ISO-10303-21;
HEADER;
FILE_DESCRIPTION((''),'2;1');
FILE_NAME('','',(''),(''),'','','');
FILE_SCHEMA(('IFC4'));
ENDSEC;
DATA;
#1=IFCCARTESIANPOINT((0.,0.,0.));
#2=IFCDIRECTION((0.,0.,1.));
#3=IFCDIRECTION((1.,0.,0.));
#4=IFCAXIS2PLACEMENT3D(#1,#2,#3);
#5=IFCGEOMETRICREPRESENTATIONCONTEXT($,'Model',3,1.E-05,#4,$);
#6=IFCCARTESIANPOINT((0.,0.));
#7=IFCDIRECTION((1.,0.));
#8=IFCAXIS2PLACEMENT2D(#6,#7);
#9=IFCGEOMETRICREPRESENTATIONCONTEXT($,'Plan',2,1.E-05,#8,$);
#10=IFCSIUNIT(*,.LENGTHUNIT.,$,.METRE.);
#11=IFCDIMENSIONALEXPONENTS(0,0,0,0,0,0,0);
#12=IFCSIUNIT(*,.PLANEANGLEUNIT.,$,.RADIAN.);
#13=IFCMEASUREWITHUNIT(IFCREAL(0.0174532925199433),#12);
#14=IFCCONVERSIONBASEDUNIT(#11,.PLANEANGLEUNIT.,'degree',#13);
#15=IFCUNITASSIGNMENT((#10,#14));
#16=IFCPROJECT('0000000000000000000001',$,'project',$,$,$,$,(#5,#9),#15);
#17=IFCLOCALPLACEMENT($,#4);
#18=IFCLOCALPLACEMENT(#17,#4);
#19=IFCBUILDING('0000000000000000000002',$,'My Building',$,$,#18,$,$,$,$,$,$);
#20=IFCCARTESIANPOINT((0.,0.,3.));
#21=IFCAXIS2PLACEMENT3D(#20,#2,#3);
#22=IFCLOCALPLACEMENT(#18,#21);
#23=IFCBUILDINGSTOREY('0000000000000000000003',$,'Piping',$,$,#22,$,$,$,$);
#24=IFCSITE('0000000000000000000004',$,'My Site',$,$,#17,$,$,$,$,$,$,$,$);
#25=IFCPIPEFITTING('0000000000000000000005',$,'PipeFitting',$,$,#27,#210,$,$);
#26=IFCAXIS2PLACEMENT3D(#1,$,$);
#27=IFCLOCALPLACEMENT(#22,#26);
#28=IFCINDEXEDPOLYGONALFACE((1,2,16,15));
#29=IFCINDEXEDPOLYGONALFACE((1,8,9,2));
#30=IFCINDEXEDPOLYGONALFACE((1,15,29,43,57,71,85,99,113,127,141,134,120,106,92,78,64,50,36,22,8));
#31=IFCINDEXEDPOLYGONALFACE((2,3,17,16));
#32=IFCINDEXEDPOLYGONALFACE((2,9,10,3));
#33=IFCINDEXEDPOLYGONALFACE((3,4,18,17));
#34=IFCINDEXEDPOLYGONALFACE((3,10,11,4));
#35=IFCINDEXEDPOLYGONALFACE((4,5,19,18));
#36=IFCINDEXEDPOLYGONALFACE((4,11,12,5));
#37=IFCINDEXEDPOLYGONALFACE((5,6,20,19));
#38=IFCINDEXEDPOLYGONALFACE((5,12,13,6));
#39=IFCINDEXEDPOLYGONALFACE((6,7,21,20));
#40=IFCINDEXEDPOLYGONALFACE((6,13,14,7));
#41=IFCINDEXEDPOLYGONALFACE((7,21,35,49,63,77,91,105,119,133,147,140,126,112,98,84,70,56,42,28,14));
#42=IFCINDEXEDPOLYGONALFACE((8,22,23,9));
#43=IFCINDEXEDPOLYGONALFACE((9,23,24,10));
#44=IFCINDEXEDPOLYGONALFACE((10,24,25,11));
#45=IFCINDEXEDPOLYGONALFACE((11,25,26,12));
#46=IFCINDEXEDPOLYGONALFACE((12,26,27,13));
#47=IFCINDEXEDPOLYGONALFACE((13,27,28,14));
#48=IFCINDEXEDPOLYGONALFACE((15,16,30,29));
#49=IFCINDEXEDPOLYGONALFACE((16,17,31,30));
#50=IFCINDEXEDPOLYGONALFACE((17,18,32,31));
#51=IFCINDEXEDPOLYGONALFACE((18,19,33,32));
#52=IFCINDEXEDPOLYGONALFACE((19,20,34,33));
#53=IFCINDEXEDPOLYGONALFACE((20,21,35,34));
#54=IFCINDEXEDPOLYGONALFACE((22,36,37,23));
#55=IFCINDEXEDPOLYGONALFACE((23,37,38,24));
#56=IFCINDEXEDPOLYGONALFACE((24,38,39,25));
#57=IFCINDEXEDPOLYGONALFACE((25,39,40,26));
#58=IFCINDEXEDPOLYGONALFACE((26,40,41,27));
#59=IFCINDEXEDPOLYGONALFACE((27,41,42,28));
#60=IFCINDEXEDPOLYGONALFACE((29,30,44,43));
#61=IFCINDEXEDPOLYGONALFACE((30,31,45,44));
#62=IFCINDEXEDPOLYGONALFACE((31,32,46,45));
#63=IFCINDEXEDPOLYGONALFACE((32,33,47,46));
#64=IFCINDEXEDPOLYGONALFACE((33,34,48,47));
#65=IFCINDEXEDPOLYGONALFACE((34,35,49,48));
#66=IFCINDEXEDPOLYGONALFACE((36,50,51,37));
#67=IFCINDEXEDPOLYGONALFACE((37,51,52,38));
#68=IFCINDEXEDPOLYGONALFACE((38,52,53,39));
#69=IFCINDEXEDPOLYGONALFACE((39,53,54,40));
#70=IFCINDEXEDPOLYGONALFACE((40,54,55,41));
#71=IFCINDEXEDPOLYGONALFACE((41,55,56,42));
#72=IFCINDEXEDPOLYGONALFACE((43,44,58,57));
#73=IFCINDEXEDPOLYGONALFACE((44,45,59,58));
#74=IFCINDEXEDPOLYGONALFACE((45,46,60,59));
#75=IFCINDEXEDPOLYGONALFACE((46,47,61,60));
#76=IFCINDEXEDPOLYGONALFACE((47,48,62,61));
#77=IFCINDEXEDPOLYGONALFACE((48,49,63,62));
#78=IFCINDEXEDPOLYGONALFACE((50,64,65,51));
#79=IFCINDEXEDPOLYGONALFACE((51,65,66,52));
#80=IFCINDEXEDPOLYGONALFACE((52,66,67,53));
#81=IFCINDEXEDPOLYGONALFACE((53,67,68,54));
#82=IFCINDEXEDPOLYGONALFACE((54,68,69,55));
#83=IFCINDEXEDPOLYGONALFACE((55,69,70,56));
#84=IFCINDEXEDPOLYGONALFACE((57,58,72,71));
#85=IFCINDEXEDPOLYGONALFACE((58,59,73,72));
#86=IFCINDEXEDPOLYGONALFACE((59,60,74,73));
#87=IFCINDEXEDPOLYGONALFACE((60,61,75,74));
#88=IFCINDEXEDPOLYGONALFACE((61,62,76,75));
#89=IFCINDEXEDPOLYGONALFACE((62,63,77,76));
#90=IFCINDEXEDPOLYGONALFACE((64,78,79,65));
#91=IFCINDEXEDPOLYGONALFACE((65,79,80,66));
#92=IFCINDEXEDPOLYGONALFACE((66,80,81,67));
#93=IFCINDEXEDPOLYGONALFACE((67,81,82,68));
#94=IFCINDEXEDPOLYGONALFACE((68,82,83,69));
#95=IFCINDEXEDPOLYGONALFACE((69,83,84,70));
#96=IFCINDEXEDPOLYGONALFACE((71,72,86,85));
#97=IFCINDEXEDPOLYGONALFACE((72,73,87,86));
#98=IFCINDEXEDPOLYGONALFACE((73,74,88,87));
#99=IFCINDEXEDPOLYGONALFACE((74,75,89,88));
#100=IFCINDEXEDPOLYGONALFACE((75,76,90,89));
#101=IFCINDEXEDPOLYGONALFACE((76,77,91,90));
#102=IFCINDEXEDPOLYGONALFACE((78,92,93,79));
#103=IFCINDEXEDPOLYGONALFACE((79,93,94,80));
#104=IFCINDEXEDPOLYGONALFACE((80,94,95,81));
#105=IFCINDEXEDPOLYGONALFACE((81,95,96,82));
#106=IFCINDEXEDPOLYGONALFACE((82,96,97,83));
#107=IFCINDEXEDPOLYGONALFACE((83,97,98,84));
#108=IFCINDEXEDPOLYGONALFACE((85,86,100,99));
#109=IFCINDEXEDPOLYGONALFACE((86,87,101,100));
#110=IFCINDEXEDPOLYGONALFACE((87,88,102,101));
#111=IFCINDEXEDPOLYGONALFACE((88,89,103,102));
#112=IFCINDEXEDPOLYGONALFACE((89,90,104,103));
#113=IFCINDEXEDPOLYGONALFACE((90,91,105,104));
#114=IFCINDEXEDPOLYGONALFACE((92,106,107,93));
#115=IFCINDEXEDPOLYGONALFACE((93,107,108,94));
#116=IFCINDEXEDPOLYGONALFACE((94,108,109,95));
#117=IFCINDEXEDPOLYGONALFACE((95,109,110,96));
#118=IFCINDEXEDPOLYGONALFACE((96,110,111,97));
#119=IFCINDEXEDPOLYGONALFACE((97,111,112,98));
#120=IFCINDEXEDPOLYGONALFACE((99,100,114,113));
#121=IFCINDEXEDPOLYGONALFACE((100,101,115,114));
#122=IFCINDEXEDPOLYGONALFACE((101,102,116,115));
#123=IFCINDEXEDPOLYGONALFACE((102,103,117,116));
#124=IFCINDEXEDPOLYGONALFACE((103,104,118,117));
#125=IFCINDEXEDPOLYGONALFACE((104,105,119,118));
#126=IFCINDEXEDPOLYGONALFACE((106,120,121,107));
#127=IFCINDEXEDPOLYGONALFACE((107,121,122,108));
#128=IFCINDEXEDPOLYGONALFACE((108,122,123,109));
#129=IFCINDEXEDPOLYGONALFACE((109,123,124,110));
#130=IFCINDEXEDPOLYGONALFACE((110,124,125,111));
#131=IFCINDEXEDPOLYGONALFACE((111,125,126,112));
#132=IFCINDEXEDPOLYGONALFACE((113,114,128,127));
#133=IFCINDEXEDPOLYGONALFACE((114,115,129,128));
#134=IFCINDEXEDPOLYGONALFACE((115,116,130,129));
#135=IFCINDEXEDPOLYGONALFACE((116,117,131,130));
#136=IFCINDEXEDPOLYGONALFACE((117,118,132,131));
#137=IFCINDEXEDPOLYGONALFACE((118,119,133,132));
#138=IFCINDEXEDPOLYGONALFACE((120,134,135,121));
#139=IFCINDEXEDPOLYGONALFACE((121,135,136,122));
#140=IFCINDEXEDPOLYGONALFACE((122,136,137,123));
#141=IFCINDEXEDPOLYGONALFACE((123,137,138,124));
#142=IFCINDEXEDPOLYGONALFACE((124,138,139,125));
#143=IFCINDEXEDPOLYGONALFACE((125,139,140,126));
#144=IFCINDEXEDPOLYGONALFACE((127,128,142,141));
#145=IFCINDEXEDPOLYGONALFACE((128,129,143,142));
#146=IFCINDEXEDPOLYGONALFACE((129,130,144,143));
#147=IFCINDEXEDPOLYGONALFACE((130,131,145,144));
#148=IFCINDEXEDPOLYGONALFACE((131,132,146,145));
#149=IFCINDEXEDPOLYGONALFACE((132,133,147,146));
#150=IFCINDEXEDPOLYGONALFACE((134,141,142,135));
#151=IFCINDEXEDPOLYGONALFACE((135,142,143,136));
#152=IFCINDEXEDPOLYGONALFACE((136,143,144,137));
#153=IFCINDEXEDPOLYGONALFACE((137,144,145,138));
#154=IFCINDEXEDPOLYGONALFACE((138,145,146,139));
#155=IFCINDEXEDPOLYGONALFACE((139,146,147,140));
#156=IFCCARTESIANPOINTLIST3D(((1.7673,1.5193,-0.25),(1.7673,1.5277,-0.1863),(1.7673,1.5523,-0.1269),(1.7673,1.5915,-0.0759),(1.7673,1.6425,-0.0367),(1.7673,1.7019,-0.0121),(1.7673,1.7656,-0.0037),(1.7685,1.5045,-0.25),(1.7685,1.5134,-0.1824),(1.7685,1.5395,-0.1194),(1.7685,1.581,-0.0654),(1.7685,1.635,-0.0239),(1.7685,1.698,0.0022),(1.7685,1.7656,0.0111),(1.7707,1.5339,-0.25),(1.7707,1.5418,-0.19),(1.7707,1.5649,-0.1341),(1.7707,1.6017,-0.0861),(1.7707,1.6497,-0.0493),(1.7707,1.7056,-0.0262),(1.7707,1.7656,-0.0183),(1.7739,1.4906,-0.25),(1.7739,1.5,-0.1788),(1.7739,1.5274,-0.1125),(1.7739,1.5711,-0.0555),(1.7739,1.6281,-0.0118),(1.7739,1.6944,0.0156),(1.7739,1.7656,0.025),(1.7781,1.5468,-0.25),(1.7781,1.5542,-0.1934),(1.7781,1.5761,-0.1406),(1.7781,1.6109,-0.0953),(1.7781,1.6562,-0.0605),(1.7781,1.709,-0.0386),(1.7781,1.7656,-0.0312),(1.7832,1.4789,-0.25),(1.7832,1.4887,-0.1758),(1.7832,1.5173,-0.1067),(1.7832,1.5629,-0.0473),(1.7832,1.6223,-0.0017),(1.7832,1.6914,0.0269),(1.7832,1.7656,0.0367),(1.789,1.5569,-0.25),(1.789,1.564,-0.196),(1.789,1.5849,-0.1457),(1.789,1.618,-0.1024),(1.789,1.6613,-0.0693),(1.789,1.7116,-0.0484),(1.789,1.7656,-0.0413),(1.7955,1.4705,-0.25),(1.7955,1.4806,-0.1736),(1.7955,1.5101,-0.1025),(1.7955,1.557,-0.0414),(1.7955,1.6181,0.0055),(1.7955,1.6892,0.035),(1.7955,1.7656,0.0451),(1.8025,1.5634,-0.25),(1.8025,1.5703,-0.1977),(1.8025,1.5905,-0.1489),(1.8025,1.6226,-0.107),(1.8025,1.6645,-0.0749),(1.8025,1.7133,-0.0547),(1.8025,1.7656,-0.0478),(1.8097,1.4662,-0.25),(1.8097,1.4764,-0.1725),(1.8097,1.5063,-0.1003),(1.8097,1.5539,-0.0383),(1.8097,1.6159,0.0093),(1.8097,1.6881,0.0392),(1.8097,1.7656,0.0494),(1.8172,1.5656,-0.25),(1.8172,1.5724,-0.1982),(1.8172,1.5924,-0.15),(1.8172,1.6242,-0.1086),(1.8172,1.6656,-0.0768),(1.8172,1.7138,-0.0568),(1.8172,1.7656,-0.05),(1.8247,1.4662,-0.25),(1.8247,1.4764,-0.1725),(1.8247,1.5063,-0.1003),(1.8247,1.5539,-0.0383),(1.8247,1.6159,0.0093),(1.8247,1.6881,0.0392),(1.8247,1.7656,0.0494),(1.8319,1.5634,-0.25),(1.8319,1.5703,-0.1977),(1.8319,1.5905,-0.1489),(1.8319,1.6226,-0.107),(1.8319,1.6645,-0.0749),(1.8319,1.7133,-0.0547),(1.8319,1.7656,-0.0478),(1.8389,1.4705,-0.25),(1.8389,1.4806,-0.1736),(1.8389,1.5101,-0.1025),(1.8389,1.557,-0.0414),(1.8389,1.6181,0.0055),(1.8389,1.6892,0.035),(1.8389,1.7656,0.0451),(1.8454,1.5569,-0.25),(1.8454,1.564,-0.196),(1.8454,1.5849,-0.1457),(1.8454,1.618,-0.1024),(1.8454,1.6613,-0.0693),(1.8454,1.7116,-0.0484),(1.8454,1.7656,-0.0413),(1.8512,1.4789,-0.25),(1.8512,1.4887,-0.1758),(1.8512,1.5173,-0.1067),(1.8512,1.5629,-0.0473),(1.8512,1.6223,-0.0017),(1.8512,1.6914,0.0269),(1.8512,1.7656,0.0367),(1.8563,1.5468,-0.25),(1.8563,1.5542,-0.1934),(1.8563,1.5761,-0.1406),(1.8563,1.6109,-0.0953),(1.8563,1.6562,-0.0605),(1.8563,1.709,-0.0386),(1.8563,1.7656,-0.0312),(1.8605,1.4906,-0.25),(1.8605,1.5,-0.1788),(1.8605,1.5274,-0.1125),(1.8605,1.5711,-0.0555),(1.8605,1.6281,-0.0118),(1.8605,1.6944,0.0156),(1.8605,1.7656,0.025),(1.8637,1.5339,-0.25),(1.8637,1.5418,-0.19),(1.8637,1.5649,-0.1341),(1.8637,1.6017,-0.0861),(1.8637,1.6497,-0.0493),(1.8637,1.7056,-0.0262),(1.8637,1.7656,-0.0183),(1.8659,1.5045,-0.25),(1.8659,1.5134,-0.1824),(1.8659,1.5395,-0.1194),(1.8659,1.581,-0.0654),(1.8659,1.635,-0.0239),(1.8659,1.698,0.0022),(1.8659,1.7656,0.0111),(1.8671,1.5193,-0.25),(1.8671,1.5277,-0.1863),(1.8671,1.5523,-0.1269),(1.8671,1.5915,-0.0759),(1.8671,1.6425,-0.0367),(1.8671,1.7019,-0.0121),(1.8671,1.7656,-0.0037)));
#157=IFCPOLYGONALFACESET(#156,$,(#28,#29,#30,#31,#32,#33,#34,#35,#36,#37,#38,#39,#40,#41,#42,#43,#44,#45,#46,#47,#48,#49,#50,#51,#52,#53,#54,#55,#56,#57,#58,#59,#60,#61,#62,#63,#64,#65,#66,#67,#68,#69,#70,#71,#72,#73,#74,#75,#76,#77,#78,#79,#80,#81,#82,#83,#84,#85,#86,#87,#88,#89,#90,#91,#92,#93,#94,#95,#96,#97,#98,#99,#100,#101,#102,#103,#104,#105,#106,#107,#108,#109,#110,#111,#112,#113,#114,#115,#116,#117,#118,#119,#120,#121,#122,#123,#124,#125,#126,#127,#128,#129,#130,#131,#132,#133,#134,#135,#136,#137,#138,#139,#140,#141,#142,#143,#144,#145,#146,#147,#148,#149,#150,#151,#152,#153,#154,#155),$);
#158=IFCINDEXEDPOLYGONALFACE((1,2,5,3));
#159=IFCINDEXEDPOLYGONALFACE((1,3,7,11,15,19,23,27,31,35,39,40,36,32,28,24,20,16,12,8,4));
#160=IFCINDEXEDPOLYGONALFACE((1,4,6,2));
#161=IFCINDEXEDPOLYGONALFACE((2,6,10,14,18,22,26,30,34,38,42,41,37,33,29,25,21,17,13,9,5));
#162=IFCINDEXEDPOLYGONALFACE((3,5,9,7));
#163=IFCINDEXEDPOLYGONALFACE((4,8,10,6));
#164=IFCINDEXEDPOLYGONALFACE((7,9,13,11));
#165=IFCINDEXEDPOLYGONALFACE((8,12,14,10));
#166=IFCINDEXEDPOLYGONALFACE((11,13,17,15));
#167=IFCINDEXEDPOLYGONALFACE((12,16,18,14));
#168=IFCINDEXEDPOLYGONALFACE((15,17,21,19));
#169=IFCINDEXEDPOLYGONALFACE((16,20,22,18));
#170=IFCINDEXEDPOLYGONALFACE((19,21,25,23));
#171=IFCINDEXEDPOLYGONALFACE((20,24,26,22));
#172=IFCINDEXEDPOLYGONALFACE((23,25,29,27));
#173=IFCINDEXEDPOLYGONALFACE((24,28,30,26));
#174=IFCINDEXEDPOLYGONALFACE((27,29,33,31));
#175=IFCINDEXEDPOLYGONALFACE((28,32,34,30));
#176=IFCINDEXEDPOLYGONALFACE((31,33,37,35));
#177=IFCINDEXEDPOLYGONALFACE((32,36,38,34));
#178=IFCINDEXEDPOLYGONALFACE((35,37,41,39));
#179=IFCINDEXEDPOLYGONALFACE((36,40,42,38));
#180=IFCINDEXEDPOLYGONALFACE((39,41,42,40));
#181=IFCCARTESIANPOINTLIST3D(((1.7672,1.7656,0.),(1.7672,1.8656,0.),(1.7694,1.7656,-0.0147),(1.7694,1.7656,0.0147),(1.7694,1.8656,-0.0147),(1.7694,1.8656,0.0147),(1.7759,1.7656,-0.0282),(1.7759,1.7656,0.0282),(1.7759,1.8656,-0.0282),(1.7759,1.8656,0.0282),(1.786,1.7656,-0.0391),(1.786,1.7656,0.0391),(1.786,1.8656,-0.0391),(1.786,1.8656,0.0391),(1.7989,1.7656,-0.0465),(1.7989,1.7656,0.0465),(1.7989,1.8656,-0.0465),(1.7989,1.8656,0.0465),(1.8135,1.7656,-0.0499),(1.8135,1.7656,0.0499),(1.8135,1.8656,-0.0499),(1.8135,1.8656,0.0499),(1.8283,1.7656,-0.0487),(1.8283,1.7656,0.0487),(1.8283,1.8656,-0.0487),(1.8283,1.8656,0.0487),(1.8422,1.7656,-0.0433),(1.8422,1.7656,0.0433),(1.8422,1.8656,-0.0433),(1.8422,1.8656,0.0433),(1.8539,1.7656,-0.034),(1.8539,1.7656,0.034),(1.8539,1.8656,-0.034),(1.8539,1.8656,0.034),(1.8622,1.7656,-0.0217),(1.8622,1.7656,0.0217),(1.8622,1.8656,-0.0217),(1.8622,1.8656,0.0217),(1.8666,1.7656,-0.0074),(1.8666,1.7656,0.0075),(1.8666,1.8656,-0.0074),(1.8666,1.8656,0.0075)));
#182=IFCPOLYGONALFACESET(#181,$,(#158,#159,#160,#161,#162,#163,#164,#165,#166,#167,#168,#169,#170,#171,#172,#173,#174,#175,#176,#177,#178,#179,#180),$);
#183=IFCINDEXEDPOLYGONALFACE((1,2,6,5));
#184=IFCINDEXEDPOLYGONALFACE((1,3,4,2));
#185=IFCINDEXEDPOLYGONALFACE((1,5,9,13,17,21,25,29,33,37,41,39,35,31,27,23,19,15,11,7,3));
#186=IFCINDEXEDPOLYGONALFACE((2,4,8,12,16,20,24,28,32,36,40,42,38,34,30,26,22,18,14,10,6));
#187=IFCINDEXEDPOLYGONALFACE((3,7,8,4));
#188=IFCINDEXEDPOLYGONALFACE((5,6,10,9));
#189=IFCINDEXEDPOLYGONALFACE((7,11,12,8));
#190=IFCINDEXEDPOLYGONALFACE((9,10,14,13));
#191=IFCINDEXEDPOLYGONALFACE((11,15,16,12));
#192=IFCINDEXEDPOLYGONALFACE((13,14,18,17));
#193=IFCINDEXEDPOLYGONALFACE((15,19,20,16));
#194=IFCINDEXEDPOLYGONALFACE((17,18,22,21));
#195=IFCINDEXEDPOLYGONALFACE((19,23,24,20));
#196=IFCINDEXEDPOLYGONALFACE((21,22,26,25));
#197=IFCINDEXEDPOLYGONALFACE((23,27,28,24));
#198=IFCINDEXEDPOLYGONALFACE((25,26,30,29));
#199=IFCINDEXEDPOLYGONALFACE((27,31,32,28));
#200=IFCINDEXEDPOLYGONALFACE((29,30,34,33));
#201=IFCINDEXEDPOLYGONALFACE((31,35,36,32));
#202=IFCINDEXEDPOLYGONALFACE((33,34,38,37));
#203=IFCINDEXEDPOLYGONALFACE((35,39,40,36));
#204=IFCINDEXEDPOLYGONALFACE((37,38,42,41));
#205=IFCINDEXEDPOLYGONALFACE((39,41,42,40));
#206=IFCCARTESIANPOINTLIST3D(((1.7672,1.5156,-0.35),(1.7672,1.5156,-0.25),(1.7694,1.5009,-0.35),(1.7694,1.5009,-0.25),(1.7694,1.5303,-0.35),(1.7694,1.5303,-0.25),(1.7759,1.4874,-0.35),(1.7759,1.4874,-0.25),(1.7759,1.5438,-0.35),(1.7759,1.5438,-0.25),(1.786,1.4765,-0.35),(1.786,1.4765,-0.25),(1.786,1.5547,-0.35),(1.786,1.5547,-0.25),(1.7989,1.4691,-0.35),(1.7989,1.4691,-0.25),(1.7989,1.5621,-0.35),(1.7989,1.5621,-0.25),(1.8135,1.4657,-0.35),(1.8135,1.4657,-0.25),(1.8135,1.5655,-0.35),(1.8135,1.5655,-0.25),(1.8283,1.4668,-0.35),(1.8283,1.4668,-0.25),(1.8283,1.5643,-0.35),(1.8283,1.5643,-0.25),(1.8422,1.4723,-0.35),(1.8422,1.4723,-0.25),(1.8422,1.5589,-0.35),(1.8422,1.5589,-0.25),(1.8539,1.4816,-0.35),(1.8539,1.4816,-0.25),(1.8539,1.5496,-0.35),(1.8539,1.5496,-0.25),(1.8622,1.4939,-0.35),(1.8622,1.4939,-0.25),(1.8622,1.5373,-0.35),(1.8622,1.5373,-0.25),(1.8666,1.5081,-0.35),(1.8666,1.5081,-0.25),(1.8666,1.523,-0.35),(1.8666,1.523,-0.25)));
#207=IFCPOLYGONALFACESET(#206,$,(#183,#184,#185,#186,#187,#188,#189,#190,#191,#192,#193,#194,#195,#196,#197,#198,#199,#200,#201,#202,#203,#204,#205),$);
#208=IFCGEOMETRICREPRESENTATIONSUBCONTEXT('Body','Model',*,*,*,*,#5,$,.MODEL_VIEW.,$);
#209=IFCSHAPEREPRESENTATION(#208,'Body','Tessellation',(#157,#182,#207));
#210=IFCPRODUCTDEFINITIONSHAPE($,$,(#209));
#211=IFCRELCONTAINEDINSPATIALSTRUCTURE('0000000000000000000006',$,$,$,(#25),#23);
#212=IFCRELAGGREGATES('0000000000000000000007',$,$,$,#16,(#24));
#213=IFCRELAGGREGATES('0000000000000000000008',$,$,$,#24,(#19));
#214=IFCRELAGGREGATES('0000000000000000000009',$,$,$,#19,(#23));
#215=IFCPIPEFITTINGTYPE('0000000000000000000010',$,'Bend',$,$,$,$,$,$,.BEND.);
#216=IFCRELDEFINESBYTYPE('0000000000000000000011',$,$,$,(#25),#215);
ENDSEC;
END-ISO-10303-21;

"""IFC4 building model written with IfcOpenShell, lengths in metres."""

from ifc_helpers import new_model, entity, si_unit, converted_unit, frame, origin_with_axes, origin_2d_with_axis, place, context, subcontext, project, spatial, circle, extrude, source, transform, mapped, type_object, type_shapes, element, save


model = new_model("IFC4")

# Units and contexts
model_context = context("Model", 3, precision=1e-05, world=origin_with_axes())
plan_context = context("Plan", 2, precision=1e-05, world=origin_2d_with_axis())
body_context = subcontext(model_context, "Body", "Model", "MODEL_VIEW")
ifc_project = project(units=[si_unit("LENGTHUNIT", "METRE"), converted_unit("PLANEANGLEUNIT", "degree", entity("IfcReal", 0.0174532925199433), si_unit("PLANEANGLEUNIT", "RADIAN"), dimensions=[0, 0, 0, 0, 0, 0, 0])], contexts=[model_context, plan_context])

# Site, building, storey
site_placement = place(None, origin_with_axes())
site = spatial("IfcSite", under=ifc_project, at=site_placement, Name="My Site")
building_placement = place(site_placement, origin_with_axes())
building = spatial("IfcBuilding", under=site, at=building_placement, Name="My Building")
storey_placement = place(building_placement, frame((0.0, 0.0, 3.0), z_axis=(0.0, 0.0, 1.0), x_axis=(1.0, 0.0, 0.0)))
storey = spatial("IfcBuildingStorey", under=building, at=storey_placement, Name="Piping")

# Shared definitions
pipe_fitting_type = type_object("IfcPipeFittingType", Name="Bend", PredefinedType="BEND")
shared_shape = source(origin_with_axes(), body_context, "Body", "SolidModel", [
    entity("IfcSweptDiskSolid", entity("IfcIndexedPolyCurve", entity("IfcCartesianPointList3D", [[0.0, 0.0, -0.1], [0.0, -0.0732, -0.2768], [0.0, -0.25, -0.35]]), [entity("IfcArcIndex", [1, 2, 3])]), 0.05),
    extrude(circle(Radius=0.05), origin_with_axes(), (0.0, 0.0, -1.0), 0.1),
    extrude(circle(Radius=0.05), frame((0.0, -0.25, -0.35), z_axis=(0.0, -1.0, 0.0), x_axis=(1.0, 0.0, 0.0)), (0.0, 0.0, 1.0), 0.1),
])
type_shapes(pipe_fitting_type, [shared_shape])

# Pipe fitting
for number, where, z_axis, x_axis, name in (
    (1, (1.8172, 1.8656, 0.0), (0.0, 1.0, 0.0), (-1.0, 0.0, 0.0), "PipeFitting"),
):
    element("IfcPipeFitting", number, at=place(storey_placement, frame(where, z_axis=z_axis, x_axis=x_axis)), inside=storey, type_object=pipe_fitting_type, Name=name, context=body_context, shape_type="MappedRepresentation", body=[
        mapped(shared_shape, transform((0.0, 0.0, 0.0), x_axis=(1.0, 0.0, 0.0), y_axis=(0.0, 1.0, 0.0), z_axis=(0.0, 0.0, 1.0), scale=1.0)),
    ])

save(model, "model.ifc")
